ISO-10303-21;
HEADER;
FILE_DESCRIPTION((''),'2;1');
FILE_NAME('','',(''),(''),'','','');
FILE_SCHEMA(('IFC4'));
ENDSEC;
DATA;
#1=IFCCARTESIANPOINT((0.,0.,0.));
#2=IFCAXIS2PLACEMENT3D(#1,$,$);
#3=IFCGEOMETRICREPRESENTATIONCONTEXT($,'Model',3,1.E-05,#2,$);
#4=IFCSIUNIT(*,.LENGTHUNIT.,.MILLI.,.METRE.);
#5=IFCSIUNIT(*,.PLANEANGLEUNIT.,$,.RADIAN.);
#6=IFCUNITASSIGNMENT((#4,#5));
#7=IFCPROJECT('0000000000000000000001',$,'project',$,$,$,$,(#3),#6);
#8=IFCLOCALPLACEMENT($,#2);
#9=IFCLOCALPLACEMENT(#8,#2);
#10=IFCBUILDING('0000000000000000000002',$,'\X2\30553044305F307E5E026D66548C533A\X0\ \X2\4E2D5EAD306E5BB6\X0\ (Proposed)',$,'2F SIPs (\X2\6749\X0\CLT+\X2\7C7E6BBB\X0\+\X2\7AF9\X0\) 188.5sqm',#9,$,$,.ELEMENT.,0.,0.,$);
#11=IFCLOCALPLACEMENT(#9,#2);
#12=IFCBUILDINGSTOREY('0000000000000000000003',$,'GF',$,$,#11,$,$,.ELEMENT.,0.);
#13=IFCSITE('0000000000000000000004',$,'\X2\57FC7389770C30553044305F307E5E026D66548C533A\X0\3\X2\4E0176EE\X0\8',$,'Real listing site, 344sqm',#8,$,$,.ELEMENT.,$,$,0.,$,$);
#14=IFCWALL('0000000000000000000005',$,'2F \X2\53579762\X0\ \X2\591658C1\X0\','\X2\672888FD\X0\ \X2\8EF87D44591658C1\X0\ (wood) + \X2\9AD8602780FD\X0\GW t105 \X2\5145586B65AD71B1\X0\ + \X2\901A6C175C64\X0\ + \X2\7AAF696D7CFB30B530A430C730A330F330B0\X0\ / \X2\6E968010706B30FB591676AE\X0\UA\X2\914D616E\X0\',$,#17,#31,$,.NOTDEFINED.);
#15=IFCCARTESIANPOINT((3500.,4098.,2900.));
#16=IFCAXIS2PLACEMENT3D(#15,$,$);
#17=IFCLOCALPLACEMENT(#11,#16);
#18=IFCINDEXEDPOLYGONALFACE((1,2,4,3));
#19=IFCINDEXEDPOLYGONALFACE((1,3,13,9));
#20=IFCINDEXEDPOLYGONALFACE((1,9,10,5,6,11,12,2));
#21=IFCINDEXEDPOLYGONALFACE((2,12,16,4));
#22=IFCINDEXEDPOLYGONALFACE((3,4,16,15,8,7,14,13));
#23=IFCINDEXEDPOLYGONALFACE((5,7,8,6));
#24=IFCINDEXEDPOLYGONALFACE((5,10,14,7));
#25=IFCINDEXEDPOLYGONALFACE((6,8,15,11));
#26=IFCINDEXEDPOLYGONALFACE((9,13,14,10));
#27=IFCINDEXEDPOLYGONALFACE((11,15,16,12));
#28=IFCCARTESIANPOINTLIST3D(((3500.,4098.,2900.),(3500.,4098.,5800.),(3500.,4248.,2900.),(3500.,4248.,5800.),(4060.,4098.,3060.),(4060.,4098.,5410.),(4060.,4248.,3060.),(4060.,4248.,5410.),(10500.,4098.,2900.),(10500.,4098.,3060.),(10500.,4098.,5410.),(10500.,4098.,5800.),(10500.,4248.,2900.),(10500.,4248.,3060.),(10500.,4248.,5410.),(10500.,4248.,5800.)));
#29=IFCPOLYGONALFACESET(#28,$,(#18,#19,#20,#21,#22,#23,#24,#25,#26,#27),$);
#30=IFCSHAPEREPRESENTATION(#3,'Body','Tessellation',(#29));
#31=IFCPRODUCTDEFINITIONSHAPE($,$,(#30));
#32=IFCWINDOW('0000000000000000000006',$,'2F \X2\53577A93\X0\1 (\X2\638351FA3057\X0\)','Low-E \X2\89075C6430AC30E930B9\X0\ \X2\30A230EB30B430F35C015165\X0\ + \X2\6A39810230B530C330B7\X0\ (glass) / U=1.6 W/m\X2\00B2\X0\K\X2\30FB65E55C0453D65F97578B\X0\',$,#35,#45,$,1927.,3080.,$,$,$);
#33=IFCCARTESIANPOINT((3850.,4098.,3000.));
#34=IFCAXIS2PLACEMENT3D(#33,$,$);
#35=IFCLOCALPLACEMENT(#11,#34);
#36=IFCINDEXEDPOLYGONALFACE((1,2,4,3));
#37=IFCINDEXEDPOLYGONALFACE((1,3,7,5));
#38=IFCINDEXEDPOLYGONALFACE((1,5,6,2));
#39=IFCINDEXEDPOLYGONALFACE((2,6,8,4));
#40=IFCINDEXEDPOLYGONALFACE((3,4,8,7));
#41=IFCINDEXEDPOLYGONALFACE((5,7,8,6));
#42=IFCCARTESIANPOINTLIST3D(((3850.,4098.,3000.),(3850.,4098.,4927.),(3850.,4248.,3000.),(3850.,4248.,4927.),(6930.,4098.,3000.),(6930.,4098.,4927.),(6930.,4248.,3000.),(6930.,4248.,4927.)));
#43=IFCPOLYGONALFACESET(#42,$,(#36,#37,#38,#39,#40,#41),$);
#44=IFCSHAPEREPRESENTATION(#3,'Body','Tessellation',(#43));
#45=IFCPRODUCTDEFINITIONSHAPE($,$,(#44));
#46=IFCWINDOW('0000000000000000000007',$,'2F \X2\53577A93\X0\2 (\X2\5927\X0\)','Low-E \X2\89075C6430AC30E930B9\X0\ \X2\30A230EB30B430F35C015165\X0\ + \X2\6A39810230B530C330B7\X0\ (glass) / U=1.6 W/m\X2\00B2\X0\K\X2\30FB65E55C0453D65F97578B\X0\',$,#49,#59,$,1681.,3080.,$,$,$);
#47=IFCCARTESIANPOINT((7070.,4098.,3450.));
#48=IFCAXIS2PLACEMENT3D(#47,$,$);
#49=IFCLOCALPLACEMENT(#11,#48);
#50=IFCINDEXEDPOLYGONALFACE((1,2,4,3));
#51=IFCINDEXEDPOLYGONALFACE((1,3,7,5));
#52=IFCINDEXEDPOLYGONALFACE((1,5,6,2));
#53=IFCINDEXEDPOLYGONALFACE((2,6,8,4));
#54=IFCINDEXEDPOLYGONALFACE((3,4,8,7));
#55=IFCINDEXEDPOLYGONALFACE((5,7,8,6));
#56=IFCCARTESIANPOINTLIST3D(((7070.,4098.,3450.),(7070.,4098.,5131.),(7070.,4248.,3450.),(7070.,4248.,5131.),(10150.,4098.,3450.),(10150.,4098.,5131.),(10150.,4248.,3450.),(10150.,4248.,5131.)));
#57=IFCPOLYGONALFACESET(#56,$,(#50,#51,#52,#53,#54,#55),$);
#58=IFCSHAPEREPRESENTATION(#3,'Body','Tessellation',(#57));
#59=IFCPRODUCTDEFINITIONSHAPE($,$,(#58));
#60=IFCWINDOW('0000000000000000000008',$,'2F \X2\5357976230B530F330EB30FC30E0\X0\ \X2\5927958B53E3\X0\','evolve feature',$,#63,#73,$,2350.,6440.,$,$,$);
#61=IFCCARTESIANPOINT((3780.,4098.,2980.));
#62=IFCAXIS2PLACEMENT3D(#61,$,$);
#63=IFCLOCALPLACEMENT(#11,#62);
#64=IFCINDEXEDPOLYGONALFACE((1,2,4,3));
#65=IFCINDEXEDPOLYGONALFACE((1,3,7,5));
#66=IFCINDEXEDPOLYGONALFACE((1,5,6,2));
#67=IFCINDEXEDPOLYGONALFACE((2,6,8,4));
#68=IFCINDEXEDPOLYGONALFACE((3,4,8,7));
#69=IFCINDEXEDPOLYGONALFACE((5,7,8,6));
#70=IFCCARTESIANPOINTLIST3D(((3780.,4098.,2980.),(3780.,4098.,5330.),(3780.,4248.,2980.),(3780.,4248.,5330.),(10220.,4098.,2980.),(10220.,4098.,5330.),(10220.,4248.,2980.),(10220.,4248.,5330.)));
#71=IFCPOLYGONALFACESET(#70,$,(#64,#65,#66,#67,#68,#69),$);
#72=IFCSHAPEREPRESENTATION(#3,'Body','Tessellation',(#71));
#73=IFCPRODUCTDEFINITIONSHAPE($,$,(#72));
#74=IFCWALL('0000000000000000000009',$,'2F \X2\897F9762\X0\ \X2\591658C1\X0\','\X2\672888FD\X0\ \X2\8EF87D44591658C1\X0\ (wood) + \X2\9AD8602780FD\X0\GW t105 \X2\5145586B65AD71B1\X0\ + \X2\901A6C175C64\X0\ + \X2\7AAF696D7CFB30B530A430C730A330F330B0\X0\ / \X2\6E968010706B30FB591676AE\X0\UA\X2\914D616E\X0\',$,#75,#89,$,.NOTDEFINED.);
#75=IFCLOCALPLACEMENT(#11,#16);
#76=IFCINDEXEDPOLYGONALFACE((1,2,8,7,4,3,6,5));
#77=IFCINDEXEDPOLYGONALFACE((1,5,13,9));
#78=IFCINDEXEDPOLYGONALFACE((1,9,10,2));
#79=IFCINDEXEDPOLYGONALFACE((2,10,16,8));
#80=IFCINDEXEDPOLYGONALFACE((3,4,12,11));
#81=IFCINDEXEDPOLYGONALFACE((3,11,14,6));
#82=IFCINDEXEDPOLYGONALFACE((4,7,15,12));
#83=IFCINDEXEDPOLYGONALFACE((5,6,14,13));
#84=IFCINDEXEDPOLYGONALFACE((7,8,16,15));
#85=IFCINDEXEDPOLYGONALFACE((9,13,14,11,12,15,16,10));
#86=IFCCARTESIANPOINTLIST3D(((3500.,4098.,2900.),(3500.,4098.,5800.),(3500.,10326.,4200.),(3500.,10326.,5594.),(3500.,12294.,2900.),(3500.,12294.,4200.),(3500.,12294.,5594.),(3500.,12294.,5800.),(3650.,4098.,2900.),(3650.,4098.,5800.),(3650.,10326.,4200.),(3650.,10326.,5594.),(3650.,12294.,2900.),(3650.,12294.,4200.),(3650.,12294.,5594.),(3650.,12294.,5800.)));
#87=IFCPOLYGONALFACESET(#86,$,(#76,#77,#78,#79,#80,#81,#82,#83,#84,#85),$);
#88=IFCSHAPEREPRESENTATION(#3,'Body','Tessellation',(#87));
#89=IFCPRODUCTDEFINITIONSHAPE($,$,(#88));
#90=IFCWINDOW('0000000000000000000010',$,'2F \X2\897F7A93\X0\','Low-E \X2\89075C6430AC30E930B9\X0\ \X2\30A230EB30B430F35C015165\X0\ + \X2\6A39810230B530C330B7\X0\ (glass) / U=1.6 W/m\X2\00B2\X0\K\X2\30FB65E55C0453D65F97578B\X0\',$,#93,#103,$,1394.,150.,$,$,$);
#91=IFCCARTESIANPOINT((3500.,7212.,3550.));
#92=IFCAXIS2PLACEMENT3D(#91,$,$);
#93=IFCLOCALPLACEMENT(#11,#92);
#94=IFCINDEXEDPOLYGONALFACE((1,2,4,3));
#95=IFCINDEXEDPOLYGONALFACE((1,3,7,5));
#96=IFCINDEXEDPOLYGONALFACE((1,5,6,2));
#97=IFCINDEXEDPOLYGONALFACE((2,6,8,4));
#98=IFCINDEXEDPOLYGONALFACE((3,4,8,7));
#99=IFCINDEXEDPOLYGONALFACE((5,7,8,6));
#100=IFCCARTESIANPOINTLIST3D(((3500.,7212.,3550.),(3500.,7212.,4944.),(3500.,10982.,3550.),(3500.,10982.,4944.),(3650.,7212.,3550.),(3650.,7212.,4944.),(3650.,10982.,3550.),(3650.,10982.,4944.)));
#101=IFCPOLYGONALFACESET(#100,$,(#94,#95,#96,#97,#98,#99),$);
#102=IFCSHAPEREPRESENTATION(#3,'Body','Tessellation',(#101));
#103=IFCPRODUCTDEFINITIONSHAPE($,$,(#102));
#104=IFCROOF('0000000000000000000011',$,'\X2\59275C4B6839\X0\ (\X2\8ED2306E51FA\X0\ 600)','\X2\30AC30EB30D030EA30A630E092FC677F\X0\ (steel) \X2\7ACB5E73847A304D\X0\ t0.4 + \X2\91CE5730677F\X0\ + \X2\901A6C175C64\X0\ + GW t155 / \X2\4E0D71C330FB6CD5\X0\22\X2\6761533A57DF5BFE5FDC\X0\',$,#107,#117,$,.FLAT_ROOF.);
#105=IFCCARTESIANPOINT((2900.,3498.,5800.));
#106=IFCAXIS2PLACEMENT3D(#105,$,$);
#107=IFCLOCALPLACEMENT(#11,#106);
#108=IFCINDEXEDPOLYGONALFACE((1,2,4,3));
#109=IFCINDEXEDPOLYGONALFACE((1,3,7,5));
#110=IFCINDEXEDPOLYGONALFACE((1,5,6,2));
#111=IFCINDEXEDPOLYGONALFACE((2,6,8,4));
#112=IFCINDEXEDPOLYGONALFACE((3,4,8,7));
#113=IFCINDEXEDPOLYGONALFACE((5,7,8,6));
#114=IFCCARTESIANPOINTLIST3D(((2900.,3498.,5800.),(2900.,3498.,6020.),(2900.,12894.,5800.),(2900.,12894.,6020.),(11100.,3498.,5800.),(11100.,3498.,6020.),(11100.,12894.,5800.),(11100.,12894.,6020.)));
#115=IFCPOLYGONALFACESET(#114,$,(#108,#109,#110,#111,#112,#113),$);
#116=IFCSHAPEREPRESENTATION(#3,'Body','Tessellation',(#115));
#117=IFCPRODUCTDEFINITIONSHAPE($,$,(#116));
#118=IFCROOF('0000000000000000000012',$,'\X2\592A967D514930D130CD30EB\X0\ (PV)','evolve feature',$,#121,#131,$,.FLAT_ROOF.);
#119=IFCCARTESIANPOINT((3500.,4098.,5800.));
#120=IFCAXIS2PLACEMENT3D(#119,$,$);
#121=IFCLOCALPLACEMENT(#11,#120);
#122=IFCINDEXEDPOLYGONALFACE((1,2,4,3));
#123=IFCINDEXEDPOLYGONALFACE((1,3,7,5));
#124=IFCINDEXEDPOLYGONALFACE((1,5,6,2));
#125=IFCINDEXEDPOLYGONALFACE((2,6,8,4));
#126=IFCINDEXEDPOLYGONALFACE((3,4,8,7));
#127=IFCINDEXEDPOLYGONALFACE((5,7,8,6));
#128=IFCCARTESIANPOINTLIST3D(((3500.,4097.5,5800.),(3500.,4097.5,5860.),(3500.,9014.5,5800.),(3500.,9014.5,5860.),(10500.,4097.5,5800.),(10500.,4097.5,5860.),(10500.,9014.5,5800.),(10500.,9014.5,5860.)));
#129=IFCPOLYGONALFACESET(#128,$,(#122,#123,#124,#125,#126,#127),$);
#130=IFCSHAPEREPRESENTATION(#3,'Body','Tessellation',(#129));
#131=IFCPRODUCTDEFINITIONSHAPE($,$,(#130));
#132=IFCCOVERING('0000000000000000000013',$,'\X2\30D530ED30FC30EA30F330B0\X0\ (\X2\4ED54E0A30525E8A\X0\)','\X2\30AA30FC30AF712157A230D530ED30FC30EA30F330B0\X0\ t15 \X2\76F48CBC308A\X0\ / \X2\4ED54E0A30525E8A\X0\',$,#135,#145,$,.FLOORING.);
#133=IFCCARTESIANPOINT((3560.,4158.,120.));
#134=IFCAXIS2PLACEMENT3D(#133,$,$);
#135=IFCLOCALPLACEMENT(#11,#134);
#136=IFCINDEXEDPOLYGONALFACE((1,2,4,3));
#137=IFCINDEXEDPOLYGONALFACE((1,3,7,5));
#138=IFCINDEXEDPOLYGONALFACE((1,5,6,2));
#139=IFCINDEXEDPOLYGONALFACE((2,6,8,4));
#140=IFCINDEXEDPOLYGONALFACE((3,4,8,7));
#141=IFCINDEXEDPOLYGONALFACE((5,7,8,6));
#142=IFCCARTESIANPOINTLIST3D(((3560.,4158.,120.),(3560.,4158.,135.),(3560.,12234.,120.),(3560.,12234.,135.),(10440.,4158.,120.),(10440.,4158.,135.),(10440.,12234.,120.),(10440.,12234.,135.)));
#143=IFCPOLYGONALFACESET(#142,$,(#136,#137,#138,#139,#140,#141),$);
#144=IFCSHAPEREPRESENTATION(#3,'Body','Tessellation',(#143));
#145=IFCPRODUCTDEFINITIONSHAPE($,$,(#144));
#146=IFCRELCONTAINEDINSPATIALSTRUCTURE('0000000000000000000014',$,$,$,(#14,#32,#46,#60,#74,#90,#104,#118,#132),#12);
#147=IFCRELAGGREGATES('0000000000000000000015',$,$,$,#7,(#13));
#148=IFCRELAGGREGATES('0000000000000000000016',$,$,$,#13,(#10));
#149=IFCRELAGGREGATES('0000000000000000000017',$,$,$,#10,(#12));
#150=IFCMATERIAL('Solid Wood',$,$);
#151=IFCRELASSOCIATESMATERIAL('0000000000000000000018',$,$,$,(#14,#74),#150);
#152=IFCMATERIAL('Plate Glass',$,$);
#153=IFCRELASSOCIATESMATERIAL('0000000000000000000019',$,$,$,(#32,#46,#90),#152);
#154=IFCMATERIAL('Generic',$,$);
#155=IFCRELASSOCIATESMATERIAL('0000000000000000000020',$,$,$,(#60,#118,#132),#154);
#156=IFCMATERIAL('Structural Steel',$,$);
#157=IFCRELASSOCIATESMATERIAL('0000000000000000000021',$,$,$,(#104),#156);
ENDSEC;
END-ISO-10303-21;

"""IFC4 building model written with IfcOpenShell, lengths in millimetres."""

from ifc_helpers import new_model, si_unit, frame, frame_2d, origin, place, context, project, spatial, rectangle, extrude, material, element, fill, save


model = new_model("IFC4")

# Units and contexts
model_context = context("Model", 3, precision=1e-05, world=origin())
ifc_project = project(units=[si_unit("LENGTHUNIT", "METRE", prefix="MILLI"), si_unit("PLANEANGLEUNIT", "RADIAN")], contexts=[model_context])

# Site, building, storey
site_placement = place(None, origin())
site = spatial("IfcSite", under=ifc_project, at=site_placement, Name="埼玉県さいたま市浦和区3丁目8", ObjectType="Real listing site, 344sqm", CompositionType="ELEMENT", RefElevation=0.0)
building_placement = place(site_placement, origin())
building = spatial("IfcBuilding", under=site, at=building_placement, Name="さいたま市浦和区 中庭の家 (Proposed)", ObjectType="2F SIPs (杉CLT+籾殻+竹) 188.5sqm", CompositionType="ELEMENT", ElevationOfRefHeight=0.0, ElevationOfTerrain=0.0)
storey_placement = place(building_placement, origin())
storey = spatial("IfcBuildingStorey", under=building, at=storey_placement, Name="GF", CompositionType="ELEMENT", Elevation=0.0)

# Shared definitions
ifc_material_1 = material(Name="Solid Wood")
ifc_material_2 = material(Name="Generic")

# Shared definitions
ifc_material_3 = material(Name="Plate Glass")

# Wall, openings, windows
wall_1_placement = place(storey_placement, frame((3500.0, 4098.0, 2900.0)))
wall_1 = element("IfcWall", 1, at=wall_1_placement, inside=storey, material=ifc_material_1, Name="2F 南面 外壁", Description="木製 軸組外壁 (wood) + 高性能GW t105 充填断熱 + 通気層 + 窯業系サイディング / 準耐火・外皮UA配慮", PredefinedType="NOTDEFINED", context=model_context, shape_type="SweptSolid", body=[
    extrude(rectangle(XDim=7000.0, YDim=150.0, at=frame_2d((3500.0, 75.0))), frame((3500.0, 4098.0, 2900.0)), (0.0, 0.0, 1.0), 2900.0),
])
opening_1_placement = place(storey_placement, frame((3850.0, 4098.0, 3000.0)))
opening_1 = element("IfcOpeningElement", 2, at=opening_1_placement, cuts=wall_1, PredefinedType="NOTDEFINED", context=model_context, shape_type="SweptSolid", body=[
    extrude(rectangle(XDim=3080.0, YDim=150.0, at=frame_2d((1540.0, 75.0))), frame((3850.0, 4098.0, 3000.0)), (0.0, 0.0, 1.0), 1927.0),
])
opening_2_placement = place(storey_placement, frame((7070.0, 4098.0, 3450.0)))
opening_2 = element("IfcOpeningElement", 3, at=opening_2_placement, cuts=wall_1, PredefinedType="NOTDEFINED", context=model_context, shape_type="SweptSolid", body=[
    extrude(rectangle(XDim=3080.0, YDim=150.0, at=frame_2d((1540.0, 75.0))), frame((7070.0, 4098.0, 3450.0)), (0.0, 0.0, 1.0), 1681.0),
])
opening_3_placement = place(storey_placement, frame((3780.0, 4098.0, 2980.0)))
opening_3 = element("IfcOpeningElement", 4, at=opening_3_placement, cuts=wall_1, PredefinedType="NOTDEFINED", context=model_context, shape_type="SweptSolid", body=[
    extrude(rectangle(XDim=6440.0, YDim=150.0, at=frame_2d((3220.0, 75.0))), frame((3780.0, 4098.0, 2980.0)), (0.0, 0.0, 1.0), 2350.0),
])
window_1_placement = place(storey_placement, frame((3850.0, 4098.0, 3000.0)))
window_1 = element("IfcWindow", 5, at=window_1_placement, inside=storey, material=ifc_material_3, Name="2F 南窓1 (掃出し)", Description="Low-E 複層ガラス アルゴン封入 + 樹脂サッシ (glass) / U=1.6 W/m²K・日射取得型", OverallHeight=1927.0, OverallWidth=3080.0, context=model_context, shape_type="SweptSolid", body=[
    extrude(rectangle(XDim=3080.0, YDim=150.0, at=frame_2d((1540.0, 75.0))), frame((3850.0, 4098.0, 3000.0)), (0.0, 0.0, 1.0), 1927.0),
])
fill(opening_1, window_1)
window_2_placement = place(storey_placement, frame((7070.0, 4098.0, 3450.0)))
window_2 = element("IfcWindow", 6, at=window_2_placement, inside=storey, material=ifc_material_3, Name="2F 南窓2 (大)", Description="Low-E 複層ガラス アルゴン封入 + 樹脂サッシ (glass) / U=1.6 W/m²K・日射取得型", OverallHeight=1681.0, OverallWidth=3080.0, context=model_context, shape_type="SweptSolid", body=[
    extrude(rectangle(XDim=3080.0, YDim=150.0, at=frame_2d((1540.0, 75.0))), frame((7070.0, 4098.0, 3450.0)), (0.0, 0.0, 1.0), 1681.0),
])
fill(opening_2, window_2)
window_3_placement = place(storey_placement, frame((3780.0, 4098.0, 2980.0)))
window_3 = element("IfcWindow", 7, at=window_3_placement, inside=storey, material=ifc_material_2, Name="2F 南面サンルーム 大開口", Description="evolve feature", OverallHeight=2350.0, OverallWidth=6440.0, context=model_context, shape_type="SweptSolid", body=[
    extrude(rectangle(XDim=6440.0, YDim=150.0, at=frame_2d((3220.0, 75.0))), frame((3780.0, 4098.0, 2980.0)), (0.0, 0.0, 1.0), 2350.0),
])
fill(opening_3, window_3)

# Wall, opening, window
wall_2_placement = place(storey_placement, frame((3500.0, 4098.0, 2900.0)))
wall_2 = element("IfcWall", 8, at=wall_2_placement, inside=storey, material=ifc_material_1, Name="2F 西面 外壁", Description="木製 軸組外壁 (wood) + 高性能GW t105 充填断熱 + 通気層 + 窯業系サイディング / 準耐火・外皮UA配慮", PredefinedType="NOTDEFINED", context=model_context, shape_type="SweptSolid", body=[
    extrude(rectangle(XDim=150.0, YDim=8196.0, at=frame_2d((75.0, 4098.0))), frame((3500.0, 4098.0, 2900.0)), (0.0, 0.0, 1.0), 2900.0),
])
opening_4_placement = place(storey_placement, frame((3500.0, 7212.0, 3550.0)))
opening_4 = element("IfcOpeningElement", 9, at=opening_4_placement, cuts=wall_2, PredefinedType="NOTDEFINED", context=model_context, shape_type="SweptSolid", body=[
    extrude(rectangle(XDim=150.0, YDim=3770.0, at=frame_2d((75.0, 1885.0))), frame((3500.0, 7212.0, 3550.0)), (0.0, 0.0, 1.0), 1394.0),
])
window_4_placement = place(storey_placement, frame((3500.0, 7212.0, 3550.0)))
window_4 = element("IfcWindow", 10, at=window_4_placement, inside=storey, material=ifc_material_3, Name="2F 西窓", Description="Low-E 複層ガラス アルゴン封入 + 樹脂サッシ (glass) / U=1.6 W/m²K・日射取得型", OverallHeight=1394.0, OverallWidth=150.0, context=model_context, shape_type="SweptSolid", body=[
    extrude(rectangle(XDim=150.0, YDim=3770.0, at=frame_2d((75.0, 1885.0))), frame((3500.0, 7212.0, 3550.0)), (0.0, 0.0, 1.0), 1394.0),
])
fill(opening_4, window_4)

# Roofs
ifc_material_4 = material(Name="Structural Steel")
roof_1_placement = place(storey_placement, frame((2900.0, 3498.0, 5800.0)))
element("IfcRoof", 11, at=roof_1_placement, inside=storey, material=ifc_material_4, Name="大屋根 (軒の出 600)", Description="ガルバリウム鋼板 (steel) 立平葺き t0.4 + 野地板 + 通気層 + GW t155 / 不燃・法22条区域対応", PredefinedType="FLAT_ROOF", context=model_context, shape_type="SweptSolid", body=[
    extrude(rectangle(XDim=8200.0, YDim=9396.0, at=frame_2d((4100.0, 4698.0))), frame((2900.0, 3498.0, 5800.0)), (0.0, 0.0, 1.0), 220.0),
])
roof_2_placement = place(storey_placement, frame((3500.0, 4098.0, 5800.0)))
element("IfcRoof", 12, at=roof_2_placement, inside=storey, material=ifc_material_2, Name="太陽光パネル (PV)", Description="evolve feature", PredefinedType="FLAT_ROOF", context=model_context, shape_type="SweptSolid", body=[
    extrude(rectangle(XDim=7000.0, YDim=4917.0, at=frame_2d((3500.0, 2458.0))), frame((3500.0, 4098.0, 5800.0)), (0.0, 0.0, 1.0), 60.0),
])

# Covering
covering_placement = place(storey_placement, frame((3560.0, 4158.0, 120.0)))
element("IfcCovering", 13, at=covering_placement, inside=storey, material=ifc_material_2, Name="フローリング (仕上げ床)", Description="オーク無垢フローリング t15 直貼り / 仕上げ床", PredefinedType="FLOORING", context=model_context, shape_type="SweptSolid", body=[
    extrude(rectangle(XDim=6880.0, YDim=8076.0, at=frame_2d((3440.0, 4038.0))), frame((3560.0, 4158.0, 120.0)), (0.0, 0.0, 1.0), 15.0),
])

save(model, "model.ifc")
